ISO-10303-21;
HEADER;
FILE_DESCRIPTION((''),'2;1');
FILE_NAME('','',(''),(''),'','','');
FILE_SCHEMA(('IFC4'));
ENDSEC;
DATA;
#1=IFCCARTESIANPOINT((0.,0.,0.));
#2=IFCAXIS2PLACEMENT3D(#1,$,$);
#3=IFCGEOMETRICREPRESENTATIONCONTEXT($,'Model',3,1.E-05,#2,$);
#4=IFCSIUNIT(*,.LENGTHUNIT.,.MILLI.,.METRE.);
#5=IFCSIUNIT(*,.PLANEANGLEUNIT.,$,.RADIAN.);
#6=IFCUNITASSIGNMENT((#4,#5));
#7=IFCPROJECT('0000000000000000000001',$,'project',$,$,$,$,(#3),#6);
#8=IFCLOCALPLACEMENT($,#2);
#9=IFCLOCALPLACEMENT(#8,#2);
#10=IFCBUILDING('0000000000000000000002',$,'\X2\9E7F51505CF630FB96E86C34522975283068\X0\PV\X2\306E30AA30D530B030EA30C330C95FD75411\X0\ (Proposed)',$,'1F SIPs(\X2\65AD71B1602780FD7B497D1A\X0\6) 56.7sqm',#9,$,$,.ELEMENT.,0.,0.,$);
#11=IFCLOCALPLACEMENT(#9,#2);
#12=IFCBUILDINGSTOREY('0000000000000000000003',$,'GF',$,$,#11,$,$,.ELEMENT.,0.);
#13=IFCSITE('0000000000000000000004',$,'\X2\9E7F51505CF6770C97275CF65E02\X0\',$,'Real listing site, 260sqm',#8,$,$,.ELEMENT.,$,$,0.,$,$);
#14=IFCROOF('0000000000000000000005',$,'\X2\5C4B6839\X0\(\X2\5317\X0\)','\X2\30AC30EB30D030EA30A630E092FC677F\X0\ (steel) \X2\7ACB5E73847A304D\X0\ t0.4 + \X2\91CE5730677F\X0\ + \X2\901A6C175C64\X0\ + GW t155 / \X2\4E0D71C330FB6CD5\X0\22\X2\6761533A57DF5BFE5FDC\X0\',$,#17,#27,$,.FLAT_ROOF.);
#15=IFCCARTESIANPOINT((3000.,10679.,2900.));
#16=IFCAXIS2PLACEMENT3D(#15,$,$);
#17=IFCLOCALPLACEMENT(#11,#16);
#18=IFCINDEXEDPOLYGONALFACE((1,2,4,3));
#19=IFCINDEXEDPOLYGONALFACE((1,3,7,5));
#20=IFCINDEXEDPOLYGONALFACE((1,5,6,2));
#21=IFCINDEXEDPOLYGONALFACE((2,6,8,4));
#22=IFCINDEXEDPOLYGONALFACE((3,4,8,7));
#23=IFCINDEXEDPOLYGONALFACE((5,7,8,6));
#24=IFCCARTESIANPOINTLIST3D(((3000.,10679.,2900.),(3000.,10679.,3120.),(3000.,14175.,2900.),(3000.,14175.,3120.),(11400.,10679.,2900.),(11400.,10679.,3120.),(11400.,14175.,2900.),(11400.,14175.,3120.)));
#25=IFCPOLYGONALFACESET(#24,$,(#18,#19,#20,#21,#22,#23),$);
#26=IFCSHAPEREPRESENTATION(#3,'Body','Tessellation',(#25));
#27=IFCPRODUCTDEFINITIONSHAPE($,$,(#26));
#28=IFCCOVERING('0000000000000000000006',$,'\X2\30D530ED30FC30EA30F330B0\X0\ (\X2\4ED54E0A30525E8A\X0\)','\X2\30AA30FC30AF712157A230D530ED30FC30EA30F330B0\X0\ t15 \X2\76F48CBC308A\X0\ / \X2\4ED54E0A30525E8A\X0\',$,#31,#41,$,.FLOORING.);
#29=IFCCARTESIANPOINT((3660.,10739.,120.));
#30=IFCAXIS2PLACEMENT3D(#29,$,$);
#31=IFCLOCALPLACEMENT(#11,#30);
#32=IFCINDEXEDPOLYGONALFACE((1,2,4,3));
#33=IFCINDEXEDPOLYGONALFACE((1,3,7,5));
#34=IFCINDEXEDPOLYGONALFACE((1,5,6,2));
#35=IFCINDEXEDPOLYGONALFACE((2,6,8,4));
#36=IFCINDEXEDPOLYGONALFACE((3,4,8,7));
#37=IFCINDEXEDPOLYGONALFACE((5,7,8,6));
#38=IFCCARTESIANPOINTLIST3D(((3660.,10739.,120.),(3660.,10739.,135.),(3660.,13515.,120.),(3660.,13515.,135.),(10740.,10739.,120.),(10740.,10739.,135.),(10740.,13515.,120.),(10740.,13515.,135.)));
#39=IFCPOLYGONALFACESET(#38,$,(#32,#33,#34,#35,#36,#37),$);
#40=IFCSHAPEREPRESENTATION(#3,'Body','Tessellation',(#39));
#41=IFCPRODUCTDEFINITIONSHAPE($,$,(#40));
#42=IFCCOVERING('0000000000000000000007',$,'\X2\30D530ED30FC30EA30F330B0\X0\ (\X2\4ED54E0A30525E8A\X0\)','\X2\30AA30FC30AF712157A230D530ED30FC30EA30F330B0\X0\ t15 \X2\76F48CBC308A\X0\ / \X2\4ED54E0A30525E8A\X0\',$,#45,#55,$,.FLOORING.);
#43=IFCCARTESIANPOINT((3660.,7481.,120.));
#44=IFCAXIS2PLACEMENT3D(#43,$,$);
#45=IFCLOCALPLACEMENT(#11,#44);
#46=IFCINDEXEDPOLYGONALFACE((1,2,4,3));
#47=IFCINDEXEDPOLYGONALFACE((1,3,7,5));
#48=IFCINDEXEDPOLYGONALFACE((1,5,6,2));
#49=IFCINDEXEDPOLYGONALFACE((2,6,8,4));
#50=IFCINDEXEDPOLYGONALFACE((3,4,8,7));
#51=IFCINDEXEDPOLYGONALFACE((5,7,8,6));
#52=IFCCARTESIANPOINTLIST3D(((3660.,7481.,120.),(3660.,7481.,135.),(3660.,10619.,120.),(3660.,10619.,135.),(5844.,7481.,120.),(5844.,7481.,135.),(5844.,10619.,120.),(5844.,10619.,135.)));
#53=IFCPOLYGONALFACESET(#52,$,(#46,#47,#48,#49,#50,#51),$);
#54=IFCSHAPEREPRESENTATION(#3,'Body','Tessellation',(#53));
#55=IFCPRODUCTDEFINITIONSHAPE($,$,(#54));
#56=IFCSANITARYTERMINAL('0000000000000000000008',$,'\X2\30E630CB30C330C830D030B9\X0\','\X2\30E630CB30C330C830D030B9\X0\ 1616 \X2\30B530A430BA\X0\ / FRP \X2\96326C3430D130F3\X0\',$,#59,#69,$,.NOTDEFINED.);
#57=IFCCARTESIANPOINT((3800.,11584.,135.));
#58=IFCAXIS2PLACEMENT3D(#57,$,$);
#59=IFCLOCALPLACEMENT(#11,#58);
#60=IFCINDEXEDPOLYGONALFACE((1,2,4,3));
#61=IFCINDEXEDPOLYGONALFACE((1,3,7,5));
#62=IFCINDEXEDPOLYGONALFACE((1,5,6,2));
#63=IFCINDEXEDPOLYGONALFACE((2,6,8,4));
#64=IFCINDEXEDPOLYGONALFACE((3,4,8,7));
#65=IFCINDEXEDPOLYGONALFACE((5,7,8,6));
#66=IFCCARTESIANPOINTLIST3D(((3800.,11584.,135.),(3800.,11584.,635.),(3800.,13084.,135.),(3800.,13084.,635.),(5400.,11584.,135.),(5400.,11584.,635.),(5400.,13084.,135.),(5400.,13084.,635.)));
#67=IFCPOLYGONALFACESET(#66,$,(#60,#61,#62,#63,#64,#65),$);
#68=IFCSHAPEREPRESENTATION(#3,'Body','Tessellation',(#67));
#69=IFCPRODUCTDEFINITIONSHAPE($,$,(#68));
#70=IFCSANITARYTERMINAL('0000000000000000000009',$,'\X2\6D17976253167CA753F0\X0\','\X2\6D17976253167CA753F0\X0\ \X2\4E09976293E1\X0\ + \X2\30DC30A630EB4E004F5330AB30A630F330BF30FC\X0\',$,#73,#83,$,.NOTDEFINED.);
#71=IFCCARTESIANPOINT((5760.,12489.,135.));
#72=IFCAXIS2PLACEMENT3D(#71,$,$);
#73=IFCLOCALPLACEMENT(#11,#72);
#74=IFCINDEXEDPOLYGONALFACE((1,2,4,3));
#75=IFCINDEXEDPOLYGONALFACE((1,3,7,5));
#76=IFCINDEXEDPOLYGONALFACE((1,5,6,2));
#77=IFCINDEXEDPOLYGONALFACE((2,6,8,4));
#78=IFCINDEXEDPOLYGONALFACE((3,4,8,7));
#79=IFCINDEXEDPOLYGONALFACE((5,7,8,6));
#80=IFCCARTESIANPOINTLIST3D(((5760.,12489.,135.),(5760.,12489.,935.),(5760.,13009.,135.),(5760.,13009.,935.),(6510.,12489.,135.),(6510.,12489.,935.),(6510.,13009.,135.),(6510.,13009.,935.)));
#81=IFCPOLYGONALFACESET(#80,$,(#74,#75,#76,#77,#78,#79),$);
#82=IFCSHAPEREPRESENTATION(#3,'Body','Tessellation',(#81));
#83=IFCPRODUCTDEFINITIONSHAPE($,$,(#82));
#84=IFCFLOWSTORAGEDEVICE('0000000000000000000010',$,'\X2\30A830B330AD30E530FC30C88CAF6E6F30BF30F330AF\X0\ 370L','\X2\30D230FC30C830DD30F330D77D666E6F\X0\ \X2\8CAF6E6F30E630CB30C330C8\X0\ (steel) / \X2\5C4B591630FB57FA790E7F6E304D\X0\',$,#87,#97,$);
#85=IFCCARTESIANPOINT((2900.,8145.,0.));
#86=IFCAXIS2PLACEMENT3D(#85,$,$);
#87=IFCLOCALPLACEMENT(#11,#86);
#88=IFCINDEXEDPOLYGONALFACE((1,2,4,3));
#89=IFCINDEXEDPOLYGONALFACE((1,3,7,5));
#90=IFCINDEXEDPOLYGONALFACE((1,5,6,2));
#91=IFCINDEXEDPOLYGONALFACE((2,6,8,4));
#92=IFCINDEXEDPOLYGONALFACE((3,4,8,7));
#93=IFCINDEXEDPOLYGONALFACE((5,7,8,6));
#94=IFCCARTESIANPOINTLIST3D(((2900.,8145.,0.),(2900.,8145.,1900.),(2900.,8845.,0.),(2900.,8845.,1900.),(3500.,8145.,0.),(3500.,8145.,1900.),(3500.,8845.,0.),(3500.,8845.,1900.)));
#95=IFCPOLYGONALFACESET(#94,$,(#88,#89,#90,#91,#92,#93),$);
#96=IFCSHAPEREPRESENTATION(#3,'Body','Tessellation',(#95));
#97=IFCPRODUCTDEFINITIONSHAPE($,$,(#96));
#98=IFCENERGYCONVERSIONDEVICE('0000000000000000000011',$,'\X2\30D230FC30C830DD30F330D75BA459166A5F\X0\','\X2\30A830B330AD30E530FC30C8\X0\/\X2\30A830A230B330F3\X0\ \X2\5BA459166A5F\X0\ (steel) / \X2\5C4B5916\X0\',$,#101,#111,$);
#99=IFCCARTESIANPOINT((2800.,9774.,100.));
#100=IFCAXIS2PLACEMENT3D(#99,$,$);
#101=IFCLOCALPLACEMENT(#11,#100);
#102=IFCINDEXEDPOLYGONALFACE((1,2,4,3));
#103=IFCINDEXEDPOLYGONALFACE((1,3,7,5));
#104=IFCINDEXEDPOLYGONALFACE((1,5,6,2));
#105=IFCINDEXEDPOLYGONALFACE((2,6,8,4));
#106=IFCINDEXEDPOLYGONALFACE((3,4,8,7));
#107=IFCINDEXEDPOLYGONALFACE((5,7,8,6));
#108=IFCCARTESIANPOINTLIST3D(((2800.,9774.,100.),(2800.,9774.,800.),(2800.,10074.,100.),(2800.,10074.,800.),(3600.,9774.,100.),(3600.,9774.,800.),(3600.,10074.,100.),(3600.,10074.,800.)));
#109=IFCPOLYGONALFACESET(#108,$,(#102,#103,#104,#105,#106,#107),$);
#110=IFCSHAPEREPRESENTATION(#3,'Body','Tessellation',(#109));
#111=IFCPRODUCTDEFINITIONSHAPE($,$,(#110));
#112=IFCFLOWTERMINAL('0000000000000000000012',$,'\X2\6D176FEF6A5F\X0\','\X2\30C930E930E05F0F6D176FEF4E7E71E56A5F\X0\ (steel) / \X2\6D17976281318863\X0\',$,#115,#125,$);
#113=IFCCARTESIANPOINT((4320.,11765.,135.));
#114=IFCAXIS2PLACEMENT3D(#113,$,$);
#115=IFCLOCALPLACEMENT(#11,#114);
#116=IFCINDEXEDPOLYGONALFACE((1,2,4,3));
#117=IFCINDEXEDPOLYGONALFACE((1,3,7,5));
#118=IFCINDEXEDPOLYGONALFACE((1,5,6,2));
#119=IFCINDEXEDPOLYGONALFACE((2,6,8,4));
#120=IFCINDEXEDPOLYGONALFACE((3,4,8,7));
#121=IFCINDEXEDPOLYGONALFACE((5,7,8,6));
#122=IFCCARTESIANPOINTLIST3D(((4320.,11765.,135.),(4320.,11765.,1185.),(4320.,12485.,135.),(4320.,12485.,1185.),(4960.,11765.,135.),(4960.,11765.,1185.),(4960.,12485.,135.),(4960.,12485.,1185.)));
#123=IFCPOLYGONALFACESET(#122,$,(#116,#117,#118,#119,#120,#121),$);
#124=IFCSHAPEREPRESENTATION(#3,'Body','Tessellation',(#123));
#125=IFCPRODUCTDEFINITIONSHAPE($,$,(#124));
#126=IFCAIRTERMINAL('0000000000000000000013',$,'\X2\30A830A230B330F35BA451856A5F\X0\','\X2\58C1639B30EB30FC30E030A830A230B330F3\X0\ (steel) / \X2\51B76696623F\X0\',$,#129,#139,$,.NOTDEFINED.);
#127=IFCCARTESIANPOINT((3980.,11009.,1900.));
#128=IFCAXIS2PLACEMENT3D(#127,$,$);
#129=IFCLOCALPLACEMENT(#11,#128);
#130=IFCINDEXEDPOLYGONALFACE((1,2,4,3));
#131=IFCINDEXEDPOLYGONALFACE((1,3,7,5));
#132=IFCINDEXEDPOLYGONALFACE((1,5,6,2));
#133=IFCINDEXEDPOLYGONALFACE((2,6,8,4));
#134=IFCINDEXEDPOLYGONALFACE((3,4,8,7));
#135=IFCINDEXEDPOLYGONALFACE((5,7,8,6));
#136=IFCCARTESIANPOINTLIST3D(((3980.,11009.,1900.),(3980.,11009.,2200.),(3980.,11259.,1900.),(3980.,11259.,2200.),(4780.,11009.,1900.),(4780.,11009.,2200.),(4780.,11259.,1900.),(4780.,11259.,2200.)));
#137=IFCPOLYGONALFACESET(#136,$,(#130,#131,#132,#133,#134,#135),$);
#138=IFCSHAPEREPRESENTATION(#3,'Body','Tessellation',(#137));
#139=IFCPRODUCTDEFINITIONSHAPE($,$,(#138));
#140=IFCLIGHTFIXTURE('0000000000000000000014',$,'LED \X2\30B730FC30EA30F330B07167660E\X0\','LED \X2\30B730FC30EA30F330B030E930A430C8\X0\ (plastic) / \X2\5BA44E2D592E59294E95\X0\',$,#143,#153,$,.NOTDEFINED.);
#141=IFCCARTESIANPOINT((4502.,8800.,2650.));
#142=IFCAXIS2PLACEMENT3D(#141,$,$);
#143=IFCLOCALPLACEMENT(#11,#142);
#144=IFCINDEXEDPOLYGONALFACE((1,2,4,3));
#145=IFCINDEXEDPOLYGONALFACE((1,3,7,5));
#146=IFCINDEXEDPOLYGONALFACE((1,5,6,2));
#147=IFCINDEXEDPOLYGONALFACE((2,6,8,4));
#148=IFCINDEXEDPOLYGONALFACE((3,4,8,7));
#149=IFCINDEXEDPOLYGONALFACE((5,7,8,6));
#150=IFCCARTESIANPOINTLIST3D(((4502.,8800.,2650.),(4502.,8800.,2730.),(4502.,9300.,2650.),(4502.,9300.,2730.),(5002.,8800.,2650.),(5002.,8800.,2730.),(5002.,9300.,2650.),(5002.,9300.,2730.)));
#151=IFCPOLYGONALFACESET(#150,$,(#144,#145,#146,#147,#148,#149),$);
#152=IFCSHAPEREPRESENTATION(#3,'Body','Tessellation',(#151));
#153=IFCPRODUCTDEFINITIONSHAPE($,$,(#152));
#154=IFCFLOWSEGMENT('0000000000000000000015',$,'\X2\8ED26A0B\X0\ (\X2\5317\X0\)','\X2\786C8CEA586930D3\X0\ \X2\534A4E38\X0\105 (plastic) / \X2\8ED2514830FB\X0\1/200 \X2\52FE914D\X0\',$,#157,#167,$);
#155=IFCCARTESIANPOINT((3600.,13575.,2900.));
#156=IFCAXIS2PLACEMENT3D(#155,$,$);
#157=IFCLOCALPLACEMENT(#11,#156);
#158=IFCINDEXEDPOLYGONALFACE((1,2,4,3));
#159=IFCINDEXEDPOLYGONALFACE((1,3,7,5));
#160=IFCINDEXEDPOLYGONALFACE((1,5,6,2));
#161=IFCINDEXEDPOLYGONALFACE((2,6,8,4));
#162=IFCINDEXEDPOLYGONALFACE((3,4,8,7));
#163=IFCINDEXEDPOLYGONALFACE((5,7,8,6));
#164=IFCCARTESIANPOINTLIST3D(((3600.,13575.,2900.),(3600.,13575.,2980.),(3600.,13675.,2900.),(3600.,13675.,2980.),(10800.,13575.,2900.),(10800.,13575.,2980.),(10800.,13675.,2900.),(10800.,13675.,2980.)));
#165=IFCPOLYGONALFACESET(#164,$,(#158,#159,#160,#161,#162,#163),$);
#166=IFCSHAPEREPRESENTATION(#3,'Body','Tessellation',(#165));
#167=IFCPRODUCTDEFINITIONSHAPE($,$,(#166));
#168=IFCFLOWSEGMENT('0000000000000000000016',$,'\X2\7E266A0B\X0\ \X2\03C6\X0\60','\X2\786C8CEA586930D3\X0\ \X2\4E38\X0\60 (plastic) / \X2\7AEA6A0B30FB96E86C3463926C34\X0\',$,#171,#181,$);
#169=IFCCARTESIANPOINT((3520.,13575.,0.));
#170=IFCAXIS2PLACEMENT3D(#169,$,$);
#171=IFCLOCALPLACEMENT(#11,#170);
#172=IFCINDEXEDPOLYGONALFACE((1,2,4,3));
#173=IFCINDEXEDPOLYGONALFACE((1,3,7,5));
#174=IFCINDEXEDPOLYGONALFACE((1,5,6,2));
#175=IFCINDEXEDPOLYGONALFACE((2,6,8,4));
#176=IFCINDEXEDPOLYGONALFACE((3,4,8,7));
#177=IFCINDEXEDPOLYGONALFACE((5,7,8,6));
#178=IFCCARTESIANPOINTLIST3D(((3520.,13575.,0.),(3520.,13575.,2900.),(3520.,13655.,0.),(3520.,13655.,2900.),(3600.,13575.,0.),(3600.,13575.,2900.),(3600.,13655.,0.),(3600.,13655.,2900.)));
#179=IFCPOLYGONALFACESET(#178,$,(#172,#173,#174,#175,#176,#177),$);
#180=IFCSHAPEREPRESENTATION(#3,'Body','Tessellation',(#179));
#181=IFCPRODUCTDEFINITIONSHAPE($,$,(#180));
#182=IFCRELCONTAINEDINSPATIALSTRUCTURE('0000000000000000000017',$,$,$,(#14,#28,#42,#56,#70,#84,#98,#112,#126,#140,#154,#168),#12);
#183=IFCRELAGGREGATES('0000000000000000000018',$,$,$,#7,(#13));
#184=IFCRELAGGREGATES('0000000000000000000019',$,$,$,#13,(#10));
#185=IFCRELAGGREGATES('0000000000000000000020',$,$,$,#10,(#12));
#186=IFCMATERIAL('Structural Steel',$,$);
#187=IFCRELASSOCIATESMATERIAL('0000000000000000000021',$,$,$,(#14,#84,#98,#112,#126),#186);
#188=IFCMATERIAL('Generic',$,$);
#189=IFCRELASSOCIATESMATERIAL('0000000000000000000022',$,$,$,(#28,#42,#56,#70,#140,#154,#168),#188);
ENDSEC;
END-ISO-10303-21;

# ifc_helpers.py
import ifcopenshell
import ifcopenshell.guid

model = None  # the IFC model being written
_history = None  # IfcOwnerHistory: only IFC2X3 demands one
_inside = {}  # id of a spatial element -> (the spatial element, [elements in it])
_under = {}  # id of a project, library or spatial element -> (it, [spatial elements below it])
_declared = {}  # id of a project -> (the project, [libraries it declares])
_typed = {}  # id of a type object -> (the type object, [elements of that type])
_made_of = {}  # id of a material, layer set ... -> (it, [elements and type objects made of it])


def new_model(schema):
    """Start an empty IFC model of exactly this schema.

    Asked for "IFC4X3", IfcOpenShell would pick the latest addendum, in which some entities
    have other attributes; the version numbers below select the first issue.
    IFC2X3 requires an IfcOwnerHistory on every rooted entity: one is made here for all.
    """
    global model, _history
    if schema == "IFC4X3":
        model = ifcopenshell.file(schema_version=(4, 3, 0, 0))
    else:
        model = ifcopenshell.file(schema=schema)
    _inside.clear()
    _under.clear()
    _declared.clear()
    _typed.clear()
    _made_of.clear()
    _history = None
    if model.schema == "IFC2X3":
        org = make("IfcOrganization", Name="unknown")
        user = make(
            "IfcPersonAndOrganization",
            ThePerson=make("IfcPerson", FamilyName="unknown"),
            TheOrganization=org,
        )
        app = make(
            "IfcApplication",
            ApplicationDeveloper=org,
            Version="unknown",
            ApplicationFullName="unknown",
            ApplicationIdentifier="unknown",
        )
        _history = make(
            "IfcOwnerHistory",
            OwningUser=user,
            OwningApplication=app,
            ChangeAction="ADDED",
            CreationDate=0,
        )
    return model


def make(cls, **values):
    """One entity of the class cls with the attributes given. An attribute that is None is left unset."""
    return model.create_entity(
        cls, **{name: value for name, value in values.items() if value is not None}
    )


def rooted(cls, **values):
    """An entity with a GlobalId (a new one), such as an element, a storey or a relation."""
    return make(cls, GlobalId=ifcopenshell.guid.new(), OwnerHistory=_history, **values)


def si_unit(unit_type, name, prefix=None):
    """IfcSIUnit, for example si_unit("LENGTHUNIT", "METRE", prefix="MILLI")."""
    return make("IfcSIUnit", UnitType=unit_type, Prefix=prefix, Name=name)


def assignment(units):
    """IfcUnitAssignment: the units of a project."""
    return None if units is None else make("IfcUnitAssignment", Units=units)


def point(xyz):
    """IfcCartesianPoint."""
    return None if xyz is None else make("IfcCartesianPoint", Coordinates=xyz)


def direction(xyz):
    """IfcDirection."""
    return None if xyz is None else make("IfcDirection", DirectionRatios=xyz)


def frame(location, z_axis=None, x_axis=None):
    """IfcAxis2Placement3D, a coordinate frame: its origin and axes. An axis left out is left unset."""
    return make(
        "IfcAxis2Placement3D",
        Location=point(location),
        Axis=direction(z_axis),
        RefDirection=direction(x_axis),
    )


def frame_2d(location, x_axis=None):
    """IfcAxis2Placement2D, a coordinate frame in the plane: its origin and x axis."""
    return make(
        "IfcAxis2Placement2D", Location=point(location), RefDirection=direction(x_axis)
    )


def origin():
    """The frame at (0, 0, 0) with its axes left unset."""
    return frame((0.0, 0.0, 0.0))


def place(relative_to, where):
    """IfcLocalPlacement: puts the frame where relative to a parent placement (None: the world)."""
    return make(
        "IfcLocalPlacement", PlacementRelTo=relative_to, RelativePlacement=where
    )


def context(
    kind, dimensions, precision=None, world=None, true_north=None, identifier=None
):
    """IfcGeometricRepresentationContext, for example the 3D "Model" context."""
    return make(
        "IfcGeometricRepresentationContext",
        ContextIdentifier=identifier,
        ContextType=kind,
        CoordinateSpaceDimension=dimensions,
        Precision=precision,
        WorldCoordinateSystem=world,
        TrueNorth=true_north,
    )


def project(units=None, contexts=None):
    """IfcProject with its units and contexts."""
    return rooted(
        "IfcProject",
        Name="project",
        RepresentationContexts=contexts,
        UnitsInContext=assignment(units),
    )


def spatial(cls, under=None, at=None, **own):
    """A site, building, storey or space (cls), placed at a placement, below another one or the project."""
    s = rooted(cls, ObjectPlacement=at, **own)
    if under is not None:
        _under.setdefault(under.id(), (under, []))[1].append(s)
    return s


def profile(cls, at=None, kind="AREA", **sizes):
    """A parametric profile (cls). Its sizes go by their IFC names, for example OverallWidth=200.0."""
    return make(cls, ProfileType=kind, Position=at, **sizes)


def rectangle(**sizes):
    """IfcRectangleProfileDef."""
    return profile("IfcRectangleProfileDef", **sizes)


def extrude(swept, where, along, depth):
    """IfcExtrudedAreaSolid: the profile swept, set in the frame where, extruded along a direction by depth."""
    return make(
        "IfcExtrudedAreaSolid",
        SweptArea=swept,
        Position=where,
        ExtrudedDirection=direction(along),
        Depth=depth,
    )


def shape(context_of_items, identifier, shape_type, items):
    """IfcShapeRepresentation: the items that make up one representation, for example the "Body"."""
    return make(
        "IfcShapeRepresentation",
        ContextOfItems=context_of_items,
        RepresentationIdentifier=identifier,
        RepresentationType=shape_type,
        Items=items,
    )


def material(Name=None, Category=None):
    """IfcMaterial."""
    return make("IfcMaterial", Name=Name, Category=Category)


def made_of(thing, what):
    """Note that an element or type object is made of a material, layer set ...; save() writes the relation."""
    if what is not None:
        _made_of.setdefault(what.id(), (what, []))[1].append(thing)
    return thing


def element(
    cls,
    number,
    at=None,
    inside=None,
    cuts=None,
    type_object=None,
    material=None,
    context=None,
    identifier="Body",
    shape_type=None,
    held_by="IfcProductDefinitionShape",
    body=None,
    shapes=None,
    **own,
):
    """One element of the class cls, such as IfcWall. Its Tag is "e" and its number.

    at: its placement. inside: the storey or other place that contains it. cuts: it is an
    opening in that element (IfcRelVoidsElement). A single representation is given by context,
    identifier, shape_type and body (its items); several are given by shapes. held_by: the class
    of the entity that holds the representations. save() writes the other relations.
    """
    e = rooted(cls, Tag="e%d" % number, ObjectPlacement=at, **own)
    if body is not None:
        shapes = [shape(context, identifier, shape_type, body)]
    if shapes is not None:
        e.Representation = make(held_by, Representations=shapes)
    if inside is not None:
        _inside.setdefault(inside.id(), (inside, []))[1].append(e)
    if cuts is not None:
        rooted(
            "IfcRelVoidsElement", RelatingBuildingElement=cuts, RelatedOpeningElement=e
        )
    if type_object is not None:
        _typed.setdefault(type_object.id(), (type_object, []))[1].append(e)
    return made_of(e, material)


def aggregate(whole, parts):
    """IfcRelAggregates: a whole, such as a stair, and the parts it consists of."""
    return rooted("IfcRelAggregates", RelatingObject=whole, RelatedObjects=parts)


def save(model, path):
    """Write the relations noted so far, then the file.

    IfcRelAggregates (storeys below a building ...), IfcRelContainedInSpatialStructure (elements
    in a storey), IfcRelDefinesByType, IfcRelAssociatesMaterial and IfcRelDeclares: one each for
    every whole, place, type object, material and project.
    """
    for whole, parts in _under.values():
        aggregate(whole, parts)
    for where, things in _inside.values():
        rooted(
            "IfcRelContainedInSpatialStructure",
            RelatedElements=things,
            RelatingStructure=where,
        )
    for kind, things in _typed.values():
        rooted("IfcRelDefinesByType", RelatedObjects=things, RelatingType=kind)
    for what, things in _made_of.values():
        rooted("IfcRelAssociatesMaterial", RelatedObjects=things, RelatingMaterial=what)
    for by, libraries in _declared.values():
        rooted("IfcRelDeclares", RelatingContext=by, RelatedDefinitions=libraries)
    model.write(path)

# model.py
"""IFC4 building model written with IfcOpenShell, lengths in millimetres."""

from ifc_helpers import new_model, si_unit, frame, frame_2d, origin, place, context, project, spatial, rectangle, extrude, material, element, save


model = new_model("IFC4")

# Units and contexts
model_context = context("Model", 3, precision=1e-05, world=origin())
ifc_project = project(units=[si_unit("LENGTHUNIT", "METRE", prefix="MILLI"), si_unit("PLANEANGLEUNIT", "RADIAN")], contexts=[model_context])

# Site, building, storey
site_placement = place(None, origin())
site = spatial("IfcSite", under=ifc_project, at=site_placement, Name="鹿児島県霧島市", ObjectType="Real listing site, 260sqm", CompositionType="ELEMENT", RefElevation=0.0)
building_placement = place(site_placement, origin())
building = spatial("IfcBuilding", under=site, at=building_placement, Name="鹿児島・雨水利用とPVのオフグリッド志向 (Proposed)", ObjectType="1F SIPs(断熱性能等級6) 56.7sqm", CompositionType="ELEMENT", ElevationOfRefHeight=0.0, ElevationOfTerrain=0.0)
storey_placement = place(building_placement, origin())
storey = spatial("IfcBuildingStorey", under=building, at=storey_placement, Name="GF", CompositionType="ELEMENT", Elevation=0.0)

# Roof
ifc_material_1 = material(Name="Structural Steel")
roof_placement = place(storey_placement, frame((3000.0, 10679.0, 2900.0)))
element("IfcRoof", 1, at=roof_placement, inside=storey, material=ifc_material_1, Name="屋根(北)", Description="ガルバリウム鋼板 (steel) 立平葺き t0.4 + 野地板 + 通気層 + GW t155 / 不燃・法22条区域対応", PredefinedType="FLAT_ROOF", context=model_context, shape_type="SweptSolid", body=[
    extrude(rectangle(XDim=8400.0, YDim=3496.0, at=frame_2d((4200.0, 1748.0))), frame((3000.0, 10679.0, 2900.0)), (0.0, 0.0, 1.0), 220.0),
])

# Coverings
ifc_material_2 = material(Name="Generic")
covering_1_placement = place(storey_placement, frame((3660.0, 10739.0, 120.0)))
element("IfcCovering", 2, at=covering_1_placement, inside=storey, material=ifc_material_2, Name="フローリング (仕上げ床)", Description="オーク無垢フローリング t15 直貼り / 仕上げ床", PredefinedType="FLOORING", context=model_context, shape_type="SweptSolid", body=[
    extrude(rectangle(XDim=7080.0, YDim=2776.0, at=frame_2d((3540.0, 1388.0))), frame((3660.0, 10739.0, 120.0)), (0.0, 0.0, 1.0), 15.0),
])
covering_2_placement = place(storey_placement, frame((3660.0, 7481.0, 120.0)))
element("IfcCovering", 3, at=covering_2_placement, inside=storey, material=ifc_material_2, Name="フローリング (仕上げ床)", Description="オーク無垢フローリング t15 直貼り / 仕上げ床", PredefinedType="FLOORING", context=model_context, shape_type="SweptSolid", body=[
    extrude(rectangle(XDim=2184.0, YDim=3138.0, at=frame_2d((1092.0, 1569.0))), frame((3660.0, 7481.0, 120.0)), (0.0, 0.0, 1.0), 15.0),
])

# Sanitary terminals
sanitary_terminal_1_placement = place(storey_placement, frame((3800.0, 11584.0, 135.0)))
element("IfcSanitaryTerminal", 4, at=sanitary_terminal_1_placement, inside=storey, material=ifc_material_2, Name="ユニットバス", Description="ユニットバス 1616 サイズ / FRP 防水パン", PredefinedType="NOTDEFINED", context=model_context, shape_type="SweptSolid", body=[
    extrude(rectangle(XDim=1600.0, YDim=1500.0, at=frame_2d((800.0, 750.0))), frame((3800.0, 11584.0, 135.0)), (0.0, 0.0, 1.0), 500.0),
])
sanitary_terminal_2_placement = place(storey_placement, frame((5760.0, 12489.0, 135.0)))
element("IfcSanitaryTerminal", 5, at=sanitary_terminal_2_placement, inside=storey, material=ifc_material_2, Name="洗面化粧台", Description="洗面化粧台 三面鏡 + ボウル一体カウンター", PredefinedType="NOTDEFINED", context=model_context, shape_type="SweptSolid", body=[
    extrude(rectangle(XDim=750.0, YDim=520.0, at=frame_2d((375.0, 260.0))), frame((5760.0, 12489.0, 135.0)), (0.0, 0.0, 1.0), 800.0),
])

# Flow storage device
flow_storage_device_placement = place(storey_placement, frame((2900.0, 8145.0, 0.0)))
element("IfcFlowStorageDevice", 6, at=flow_storage_device_placement, inside=storey, material=ifc_material_1, Name="エコキュート貯湯タンク 370L", Description="ヒートポンプ給湯 貯湯ユニット (steel) / 屋外・基礎置き", context=model_context, shape_type="SweptSolid", body=[
    extrude(rectangle(XDim=600.0, YDim=700.0, at=frame_2d((300.0, 350.0))), frame((2900.0, 8145.0, 0.0)), (0.0, 0.0, 1.0), 1900.0),
])

# Energy conversion device
energy_conversion_device_placement = place(storey_placement, frame((2800.0, 9774.0, 100.0)))
element("IfcEnergyConversionDevice", 7, at=energy_conversion_device_placement, inside=storey, material=ifc_material_1, Name="ヒートポンプ室外機", Description="エコキュート/エアコン 室外機 (steel) / 屋外", context=model_context, shape_type="SweptSolid", body=[
    extrude(rectangle(XDim=800.0, YDim=300.0, at=frame_2d((400.0, 150.0))), frame((2800.0, 9774.0, 100.0)), (0.0, 0.0, 1.0), 700.0),
])

# Flow terminal
flow_terminal_placement = place(storey_placement, frame((4320.0, 11765.0, 135.0)))
element("IfcFlowTerminal", 8, at=flow_terminal_placement, inside=storey, material=ifc_material_1, Name="洗濯機", Description="ドラム式洗濯乾燥機 (steel) / 洗面脱衣", context=model_context, shape_type="SweptSolid", body=[
    extrude(rectangle(XDim=640.0, YDim=720.0, at=frame_2d((320.0, 360.0))), frame((4320.0, 11765.0, 135.0)), (0.0, 0.0, 1.0), 1050.0),
])

# Air terminal
air_terminal_placement = place(storey_placement, frame((3980.0, 11009.0, 1900.0)))
element("IfcAirTerminal", 9, at=air_terminal_placement, inside=storey, material=ifc_material_1, Name="エアコン室内機", Description="壁掛ルームエアコン (steel) / 冷暖房", PredefinedType="NOTDEFINED", context=model_context, shape_type="SweptSolid", body=[
    extrude(rectangle(XDim=800.0, YDim=250.0, at=frame_2d((400.0, 125.0))), frame((3980.0, 11009.0, 1900.0)), (0.0, 0.0, 1.0), 300.0),
])

# Light fixture
light_fixture_placement = place(storey_placement, frame((4502.0, 8800.0, 2650.0)))
element("IfcLightFixture", 10, at=light_fixture_placement, inside=storey, material=ifc_material_2, Name="LED シーリング照明", Description="LED シーリングライト (plastic) / 室中央天井", PredefinedType="NOTDEFINED", context=model_context, shape_type="SweptSolid", body=[
    extrude(rectangle(XDim=500.0, YDim=500.0, at=frame_2d((250.0, 250.0))), frame((4502.0, 8800.0, 2650.0)), (0.0, 0.0, 1.0), 80.0),
])

# Flow segments
flow_segment_1_placement = place(storey_placement, frame((3600.0, 13575.0, 2900.0)))
element("IfcFlowSegment", 11, at=flow_segment_1_placement, inside=storey, material=ifc_material_2, Name="軒樋 (北)", Description="硬質塩ビ 半丸105 (plastic) / 軒先・1/200 勾配", context=model_context, shape_type="SweptSolid", body=[
    extrude(rectangle(XDim=7200.0, YDim=100.0, at=frame_2d((3600.0, 50.0))), frame((3600.0, 13575.0, 2900.0)), (0.0, 0.0, 1.0), 80.0),
])
flow_segment_2_placement = place(storey_placement, frame((3520.0, 13575.0, 0.0)))
element("IfcFlowSegment", 12, at=flow_segment_2_placement, inside=storey, material=ifc_material_2, Name="縦樋 φ60", Description="硬質塩ビ 丸60 (plastic) / 竪樋・雨水排水", context=model_context, shape_type="SweptSolid", body=[
    extrude(rectangle(XDim=80.0, YDim=80.0, at=frame_2d((40.0, 40.0))), frame((3520.0, 13575.0, 0.0)), (0.0, 0.0, 1.0), 2900.0),
])

save(model, "model.ifc")
